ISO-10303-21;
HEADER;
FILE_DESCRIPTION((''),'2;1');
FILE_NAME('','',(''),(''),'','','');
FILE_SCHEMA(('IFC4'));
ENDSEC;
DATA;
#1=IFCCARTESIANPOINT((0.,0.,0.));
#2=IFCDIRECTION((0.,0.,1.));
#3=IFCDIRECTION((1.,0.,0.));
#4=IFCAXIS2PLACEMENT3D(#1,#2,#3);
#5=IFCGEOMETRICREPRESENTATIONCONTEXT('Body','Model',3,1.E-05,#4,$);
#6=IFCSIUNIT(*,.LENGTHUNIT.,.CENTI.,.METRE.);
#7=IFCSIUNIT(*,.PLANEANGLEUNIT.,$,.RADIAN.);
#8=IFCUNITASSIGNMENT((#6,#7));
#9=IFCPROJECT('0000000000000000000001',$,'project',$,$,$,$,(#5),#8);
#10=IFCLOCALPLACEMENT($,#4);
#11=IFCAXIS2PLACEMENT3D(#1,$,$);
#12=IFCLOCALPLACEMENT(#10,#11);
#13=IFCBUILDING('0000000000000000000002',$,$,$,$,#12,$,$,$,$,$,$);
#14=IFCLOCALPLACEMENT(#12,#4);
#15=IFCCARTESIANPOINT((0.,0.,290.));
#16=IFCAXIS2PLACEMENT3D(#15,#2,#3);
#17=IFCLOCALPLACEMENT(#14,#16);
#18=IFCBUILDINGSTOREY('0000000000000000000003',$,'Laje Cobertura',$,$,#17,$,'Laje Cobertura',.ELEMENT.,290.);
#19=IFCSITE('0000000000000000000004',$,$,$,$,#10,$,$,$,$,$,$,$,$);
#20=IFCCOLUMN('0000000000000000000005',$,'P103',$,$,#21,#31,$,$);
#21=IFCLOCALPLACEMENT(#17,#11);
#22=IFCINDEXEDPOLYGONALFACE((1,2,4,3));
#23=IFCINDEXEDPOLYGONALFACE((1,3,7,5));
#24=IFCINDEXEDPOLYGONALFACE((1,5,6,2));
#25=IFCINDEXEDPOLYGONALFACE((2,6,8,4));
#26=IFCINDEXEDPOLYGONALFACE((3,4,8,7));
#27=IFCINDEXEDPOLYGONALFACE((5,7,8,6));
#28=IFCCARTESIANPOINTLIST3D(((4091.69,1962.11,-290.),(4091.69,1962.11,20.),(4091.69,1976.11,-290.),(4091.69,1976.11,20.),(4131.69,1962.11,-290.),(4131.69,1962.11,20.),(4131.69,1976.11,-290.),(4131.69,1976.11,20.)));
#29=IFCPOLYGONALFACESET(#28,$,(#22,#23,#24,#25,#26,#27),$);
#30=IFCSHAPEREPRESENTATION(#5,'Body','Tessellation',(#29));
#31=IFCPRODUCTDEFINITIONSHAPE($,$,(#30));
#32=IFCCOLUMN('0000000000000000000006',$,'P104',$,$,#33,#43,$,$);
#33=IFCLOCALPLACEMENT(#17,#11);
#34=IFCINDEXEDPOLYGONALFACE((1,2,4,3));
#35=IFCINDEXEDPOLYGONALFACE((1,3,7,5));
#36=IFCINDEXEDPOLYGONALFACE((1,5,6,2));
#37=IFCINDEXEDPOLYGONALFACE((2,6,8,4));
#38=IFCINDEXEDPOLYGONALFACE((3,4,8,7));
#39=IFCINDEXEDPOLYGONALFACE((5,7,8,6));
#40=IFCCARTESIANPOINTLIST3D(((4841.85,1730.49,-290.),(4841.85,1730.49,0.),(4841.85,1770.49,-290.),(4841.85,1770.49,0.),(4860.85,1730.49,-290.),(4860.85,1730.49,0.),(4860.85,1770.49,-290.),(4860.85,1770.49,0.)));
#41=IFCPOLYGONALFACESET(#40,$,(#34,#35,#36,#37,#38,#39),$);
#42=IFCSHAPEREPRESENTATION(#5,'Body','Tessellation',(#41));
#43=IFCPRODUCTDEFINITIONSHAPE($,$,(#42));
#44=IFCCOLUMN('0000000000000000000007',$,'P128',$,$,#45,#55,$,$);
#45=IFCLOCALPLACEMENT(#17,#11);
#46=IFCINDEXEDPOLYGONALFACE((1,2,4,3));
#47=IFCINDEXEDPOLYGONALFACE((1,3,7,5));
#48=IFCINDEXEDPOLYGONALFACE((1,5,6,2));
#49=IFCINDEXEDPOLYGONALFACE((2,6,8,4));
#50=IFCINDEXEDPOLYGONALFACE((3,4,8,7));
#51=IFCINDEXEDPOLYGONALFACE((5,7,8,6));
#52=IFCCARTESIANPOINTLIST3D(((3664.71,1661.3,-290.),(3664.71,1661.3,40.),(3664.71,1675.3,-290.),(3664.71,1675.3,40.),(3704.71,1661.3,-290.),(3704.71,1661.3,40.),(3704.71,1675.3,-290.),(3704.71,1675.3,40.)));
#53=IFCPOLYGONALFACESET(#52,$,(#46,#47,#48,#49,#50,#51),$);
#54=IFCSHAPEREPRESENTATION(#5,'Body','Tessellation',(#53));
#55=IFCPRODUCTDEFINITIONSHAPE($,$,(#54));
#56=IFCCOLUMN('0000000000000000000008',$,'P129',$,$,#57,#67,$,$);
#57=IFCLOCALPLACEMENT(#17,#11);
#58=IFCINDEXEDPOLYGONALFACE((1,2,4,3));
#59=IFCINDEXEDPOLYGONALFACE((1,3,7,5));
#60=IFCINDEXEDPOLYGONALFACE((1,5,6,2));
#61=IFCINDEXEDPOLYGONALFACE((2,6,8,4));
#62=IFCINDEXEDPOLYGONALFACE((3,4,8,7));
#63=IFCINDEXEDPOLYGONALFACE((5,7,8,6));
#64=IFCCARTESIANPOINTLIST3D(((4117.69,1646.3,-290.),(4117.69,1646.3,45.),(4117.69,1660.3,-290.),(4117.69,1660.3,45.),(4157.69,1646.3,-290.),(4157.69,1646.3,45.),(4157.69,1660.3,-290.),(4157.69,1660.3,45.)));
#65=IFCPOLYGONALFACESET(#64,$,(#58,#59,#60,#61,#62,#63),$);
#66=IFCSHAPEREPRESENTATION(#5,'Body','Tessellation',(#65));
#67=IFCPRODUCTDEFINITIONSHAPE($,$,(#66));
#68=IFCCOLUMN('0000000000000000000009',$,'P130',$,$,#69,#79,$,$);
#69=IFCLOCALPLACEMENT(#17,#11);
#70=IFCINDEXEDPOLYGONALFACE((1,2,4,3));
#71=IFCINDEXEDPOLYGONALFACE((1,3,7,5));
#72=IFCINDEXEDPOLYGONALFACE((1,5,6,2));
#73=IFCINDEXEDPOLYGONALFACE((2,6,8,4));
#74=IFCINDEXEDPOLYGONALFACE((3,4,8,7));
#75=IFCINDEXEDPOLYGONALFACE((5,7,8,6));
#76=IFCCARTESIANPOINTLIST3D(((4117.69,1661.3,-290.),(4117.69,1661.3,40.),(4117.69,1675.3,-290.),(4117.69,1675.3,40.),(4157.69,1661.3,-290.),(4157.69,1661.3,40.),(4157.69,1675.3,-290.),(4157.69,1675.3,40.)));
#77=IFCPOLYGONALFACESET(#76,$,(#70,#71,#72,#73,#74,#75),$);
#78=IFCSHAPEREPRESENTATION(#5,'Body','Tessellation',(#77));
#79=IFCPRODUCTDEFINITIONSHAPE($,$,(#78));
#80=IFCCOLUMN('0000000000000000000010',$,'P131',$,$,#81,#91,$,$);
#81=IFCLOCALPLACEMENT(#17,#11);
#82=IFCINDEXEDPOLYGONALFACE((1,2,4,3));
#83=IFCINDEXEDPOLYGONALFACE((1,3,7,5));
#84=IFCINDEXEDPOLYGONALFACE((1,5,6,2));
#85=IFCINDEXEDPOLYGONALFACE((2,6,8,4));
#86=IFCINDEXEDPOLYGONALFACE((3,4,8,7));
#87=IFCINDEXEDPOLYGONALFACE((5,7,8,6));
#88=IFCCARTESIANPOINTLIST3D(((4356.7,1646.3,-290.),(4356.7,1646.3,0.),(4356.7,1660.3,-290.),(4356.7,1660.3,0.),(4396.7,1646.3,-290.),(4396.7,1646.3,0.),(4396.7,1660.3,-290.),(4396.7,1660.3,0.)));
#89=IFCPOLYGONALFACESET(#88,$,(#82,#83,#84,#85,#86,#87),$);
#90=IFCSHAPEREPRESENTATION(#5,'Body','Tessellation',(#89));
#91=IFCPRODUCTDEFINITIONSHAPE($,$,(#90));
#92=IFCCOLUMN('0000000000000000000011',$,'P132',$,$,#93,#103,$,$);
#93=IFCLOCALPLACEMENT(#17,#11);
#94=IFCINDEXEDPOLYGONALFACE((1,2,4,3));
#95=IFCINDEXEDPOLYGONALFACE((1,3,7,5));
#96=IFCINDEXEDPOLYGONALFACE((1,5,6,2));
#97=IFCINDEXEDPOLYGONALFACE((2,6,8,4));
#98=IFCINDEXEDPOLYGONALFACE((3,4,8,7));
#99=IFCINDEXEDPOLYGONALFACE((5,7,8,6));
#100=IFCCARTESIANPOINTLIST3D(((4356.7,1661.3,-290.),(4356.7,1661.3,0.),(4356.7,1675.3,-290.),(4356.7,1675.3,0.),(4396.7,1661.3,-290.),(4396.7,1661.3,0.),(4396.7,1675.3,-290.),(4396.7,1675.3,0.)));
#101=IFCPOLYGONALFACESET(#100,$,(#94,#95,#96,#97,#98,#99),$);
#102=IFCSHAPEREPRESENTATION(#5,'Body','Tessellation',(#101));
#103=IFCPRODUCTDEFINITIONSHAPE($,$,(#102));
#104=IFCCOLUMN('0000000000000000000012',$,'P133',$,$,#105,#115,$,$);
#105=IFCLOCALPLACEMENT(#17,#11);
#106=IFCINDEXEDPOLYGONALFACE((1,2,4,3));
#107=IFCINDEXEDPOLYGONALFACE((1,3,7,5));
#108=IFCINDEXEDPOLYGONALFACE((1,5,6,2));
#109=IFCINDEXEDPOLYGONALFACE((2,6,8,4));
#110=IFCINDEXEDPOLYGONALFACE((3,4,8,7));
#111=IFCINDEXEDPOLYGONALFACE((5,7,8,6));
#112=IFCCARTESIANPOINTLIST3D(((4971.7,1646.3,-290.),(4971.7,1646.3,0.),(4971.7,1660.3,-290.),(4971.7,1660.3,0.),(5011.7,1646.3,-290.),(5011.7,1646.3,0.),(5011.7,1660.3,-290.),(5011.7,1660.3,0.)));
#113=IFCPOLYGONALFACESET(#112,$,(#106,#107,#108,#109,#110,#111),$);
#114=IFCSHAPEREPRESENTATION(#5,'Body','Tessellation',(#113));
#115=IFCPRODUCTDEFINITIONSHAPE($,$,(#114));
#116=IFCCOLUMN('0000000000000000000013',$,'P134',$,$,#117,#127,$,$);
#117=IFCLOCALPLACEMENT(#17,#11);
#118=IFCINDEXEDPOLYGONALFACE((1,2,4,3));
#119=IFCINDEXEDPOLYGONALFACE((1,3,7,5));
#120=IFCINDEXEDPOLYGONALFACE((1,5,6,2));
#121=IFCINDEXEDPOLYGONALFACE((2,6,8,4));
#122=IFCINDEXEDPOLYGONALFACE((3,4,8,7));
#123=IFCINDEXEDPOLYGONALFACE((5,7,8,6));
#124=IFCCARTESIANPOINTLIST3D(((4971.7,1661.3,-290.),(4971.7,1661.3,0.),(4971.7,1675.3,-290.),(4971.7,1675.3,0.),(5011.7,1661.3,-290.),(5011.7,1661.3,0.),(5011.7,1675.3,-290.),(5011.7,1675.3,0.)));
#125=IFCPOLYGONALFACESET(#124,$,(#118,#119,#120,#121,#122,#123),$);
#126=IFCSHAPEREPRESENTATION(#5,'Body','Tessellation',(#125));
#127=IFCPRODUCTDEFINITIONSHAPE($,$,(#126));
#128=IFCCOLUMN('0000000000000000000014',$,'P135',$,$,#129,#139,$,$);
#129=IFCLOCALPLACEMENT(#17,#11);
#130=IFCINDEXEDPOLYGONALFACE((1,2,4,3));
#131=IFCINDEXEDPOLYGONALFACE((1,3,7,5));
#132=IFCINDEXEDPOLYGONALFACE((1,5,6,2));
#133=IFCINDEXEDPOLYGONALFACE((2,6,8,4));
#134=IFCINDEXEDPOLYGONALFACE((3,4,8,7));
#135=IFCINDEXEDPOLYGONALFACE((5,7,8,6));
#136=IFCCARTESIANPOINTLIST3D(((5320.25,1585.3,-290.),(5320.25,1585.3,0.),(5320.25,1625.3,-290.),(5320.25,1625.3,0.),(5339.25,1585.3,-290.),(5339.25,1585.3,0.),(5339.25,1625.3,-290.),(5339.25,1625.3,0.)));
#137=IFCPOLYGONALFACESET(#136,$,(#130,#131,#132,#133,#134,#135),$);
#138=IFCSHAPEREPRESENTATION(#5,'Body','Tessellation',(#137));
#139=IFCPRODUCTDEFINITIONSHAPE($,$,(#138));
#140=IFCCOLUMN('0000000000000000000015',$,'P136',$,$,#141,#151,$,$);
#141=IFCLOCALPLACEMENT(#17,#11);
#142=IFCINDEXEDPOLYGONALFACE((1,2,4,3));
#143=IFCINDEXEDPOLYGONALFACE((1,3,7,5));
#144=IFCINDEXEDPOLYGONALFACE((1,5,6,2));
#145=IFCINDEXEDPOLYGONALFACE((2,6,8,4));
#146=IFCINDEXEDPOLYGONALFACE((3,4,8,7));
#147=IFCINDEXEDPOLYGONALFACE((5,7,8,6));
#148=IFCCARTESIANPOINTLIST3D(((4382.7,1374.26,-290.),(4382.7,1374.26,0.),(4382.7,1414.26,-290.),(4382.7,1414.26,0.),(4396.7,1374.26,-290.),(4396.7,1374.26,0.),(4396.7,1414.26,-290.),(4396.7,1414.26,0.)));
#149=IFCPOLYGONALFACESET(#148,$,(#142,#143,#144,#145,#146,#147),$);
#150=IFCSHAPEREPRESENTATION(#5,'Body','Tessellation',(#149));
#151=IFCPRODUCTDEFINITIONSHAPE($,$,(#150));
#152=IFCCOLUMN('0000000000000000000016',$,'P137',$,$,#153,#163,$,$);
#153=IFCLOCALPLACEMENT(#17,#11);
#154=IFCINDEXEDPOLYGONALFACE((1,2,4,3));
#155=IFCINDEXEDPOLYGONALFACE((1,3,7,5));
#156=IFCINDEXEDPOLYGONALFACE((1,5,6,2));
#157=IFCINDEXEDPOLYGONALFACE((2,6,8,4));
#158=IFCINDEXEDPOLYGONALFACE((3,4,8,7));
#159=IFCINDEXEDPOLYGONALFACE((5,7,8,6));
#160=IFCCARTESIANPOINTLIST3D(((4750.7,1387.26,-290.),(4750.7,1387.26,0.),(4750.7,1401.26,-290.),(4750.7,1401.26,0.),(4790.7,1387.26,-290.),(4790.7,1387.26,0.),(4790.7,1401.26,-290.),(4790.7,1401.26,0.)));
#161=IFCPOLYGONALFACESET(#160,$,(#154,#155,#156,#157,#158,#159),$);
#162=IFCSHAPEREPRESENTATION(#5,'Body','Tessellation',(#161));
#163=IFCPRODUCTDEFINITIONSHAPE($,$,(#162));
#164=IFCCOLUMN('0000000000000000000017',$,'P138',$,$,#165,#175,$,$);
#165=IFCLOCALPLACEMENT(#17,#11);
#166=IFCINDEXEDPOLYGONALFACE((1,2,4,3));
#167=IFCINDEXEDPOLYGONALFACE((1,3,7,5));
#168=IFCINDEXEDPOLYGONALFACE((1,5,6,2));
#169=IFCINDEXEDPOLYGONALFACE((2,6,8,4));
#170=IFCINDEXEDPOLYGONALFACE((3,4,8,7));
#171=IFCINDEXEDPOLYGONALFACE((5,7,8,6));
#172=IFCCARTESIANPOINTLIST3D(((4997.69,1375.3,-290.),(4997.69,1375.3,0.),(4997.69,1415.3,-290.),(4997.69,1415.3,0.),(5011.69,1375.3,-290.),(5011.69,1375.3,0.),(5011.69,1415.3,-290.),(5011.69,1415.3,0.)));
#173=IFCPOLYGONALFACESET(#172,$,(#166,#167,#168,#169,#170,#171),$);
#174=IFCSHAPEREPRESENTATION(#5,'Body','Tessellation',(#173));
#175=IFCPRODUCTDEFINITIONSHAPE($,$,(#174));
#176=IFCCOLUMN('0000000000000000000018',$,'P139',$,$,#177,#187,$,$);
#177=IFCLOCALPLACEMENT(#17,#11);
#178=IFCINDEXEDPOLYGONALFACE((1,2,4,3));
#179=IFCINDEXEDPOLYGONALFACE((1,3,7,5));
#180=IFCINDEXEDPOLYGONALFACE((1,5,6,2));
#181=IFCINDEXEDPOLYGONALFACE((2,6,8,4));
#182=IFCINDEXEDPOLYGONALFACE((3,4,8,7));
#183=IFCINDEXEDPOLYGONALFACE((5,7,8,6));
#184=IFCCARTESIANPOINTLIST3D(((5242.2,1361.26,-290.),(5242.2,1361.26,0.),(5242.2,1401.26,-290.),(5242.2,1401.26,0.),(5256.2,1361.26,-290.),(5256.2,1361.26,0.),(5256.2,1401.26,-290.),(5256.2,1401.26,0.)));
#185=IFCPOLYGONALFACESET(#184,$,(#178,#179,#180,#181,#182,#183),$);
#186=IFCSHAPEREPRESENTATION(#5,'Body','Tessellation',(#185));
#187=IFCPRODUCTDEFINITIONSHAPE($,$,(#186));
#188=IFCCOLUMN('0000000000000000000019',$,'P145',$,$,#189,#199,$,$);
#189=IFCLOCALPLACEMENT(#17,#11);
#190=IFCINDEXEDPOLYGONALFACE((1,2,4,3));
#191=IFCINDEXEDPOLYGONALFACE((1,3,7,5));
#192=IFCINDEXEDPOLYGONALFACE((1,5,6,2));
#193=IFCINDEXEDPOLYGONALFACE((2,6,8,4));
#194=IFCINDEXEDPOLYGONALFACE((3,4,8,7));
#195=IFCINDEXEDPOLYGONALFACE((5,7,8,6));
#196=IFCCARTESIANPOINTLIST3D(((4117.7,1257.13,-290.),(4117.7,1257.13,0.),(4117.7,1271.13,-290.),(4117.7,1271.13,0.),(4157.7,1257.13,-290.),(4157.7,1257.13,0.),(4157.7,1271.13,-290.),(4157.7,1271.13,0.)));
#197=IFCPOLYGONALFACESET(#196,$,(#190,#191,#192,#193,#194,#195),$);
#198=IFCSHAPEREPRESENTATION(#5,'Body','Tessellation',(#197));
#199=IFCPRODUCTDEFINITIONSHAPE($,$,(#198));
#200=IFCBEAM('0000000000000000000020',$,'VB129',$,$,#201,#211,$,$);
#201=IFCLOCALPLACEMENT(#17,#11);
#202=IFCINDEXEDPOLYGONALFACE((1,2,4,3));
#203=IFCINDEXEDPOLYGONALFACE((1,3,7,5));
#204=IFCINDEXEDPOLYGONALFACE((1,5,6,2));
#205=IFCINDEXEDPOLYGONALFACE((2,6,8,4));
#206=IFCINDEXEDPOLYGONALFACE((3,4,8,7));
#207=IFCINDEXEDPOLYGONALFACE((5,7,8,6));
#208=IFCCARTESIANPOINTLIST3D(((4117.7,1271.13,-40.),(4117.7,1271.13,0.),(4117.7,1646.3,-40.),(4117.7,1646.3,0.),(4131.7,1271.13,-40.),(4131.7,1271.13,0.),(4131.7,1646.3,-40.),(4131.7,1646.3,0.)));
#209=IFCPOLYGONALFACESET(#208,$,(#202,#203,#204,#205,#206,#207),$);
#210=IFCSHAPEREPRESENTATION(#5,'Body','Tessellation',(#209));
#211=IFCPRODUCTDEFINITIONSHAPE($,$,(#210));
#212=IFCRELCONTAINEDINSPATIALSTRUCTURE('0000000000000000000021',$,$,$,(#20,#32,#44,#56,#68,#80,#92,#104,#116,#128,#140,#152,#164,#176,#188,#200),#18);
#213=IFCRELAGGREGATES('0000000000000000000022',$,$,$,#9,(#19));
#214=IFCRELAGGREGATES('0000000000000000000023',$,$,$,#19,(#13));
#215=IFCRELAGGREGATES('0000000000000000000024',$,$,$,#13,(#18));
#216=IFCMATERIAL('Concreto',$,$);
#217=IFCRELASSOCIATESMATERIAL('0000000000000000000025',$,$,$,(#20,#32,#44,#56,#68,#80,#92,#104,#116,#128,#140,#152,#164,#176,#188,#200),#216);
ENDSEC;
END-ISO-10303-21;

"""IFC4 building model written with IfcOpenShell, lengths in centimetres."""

from ifc_helpers import new_model, si_unit, frame, origin, origin_with_axes, origin_2d_with_axis, place, context, project, spatial, rectangle, extrude, material, element, save


model = new_model("IFC4")

# Units and contexts
model_context = context("Model", 3, precision=1e-05, world=origin_with_axes(), identifier="Body")
ifc_project = project(units=[si_unit("LENGTHUNIT", "METRE", prefix="CENTI"), si_unit("PLANEANGLEUNIT", "RADIAN")], contexts=[model_context])

# Site, building, storey
site_placement = place(None, origin_with_axes())
site = spatial("IfcSite", under=ifc_project, at=site_placement)
building_placement = place(site_placement, origin())
building = spatial("IfcBuilding", under=site, at=building_placement)
placement = place(building_placement, origin_with_axes())
storey_placement = place(placement, frame((0.0, 0.0, 290.0), z_axis=(0.0, 0.0, 1.0), x_axis=(1.0, 0.0, 0.0)))
storey = spatial("IfcBuildingStorey", under=building, at=storey_placement, Name="Laje Cobertura", LongName="Laje Cobertura", CompositionType="ELEMENT", Elevation=290.0)

# Columns
ifc_material = material(Name="Concreto")
column_1_placement = place(storey_placement, frame((4111.69, 1969.11, 20.0), z_axis=(0.0, 0.0, 1.0), x_axis=(1.0, 0.0, 0.0)))
element("IfcColumn", 1, at=column_1_placement, inside=storey, material=ifc_material, Name="P103", context=model_context, shape_type="SolidModel", body=[
    extrude(rectangle(XDim=14.0, YDim=40.0, at=origin_2d_with_axis()), frame((0.0, 0.0, 0.0), z_axis=(0.0, 0.0, 1.0), x_axis=(0.0, -1.0, 0.0)), (0.0, 0.0, -1.0), 310.0),
])
column_2_placement = place(storey_placement, frame((4851.35, 1750.49, 0.0), z_axis=(0.0, 0.0, 1.0), x_axis=(1.0, 0.0, 0.0)))
element("IfcColumn", 2, at=column_2_placement, inside=storey, material=ifc_material, Name="P104", context=model_context, shape_type="SolidModel", body=[
    extrude(rectangle(XDim=19.0, YDim=40.0, at=origin_2d_with_axis()), origin_with_axes(), (0.0, 0.0, -1.0), 290.0),
])
column_3_placement = place(storey_placement, frame((3684.71, 1668.3, 40.0), z_axis=(0.0, 0.0, 1.0), x_axis=(1.0, 0.0, 0.0)))
element("IfcColumn", 3, at=column_3_placement, inside=storey, material=ifc_material, Name="P128", context=model_context, shape_type="SolidModel", body=[
    extrude(rectangle(XDim=14.0, YDim=40.0, at=origin_2d_with_axis()), frame((0.0, 0.0, 0.0), z_axis=(0.0, 0.0, 1.0), x_axis=(0.0, -1.0, 0.0)), (0.0, 0.0, -1.0), 330.0),
])
column_4_placement = place(storey_placement, frame((4137.69, 1653.3, 45.0), z_axis=(0.0, 0.0, 1.0), x_axis=(1.0, 0.0, 0.0)))
element("IfcColumn", 4, at=column_4_placement, inside=storey, material=ifc_material, Name="P129", context=model_context, shape_type="SolidModel", body=[
    extrude(rectangle(XDim=14.0, YDim=40.0, at=origin_2d_with_axis()), frame((0.0, 0.0, 0.0), z_axis=(0.0, 0.0, 1.0), x_axis=(0.0, -1.0, 0.0)), (0.0, 0.0, -1.0), 335.0),
])
column_5_placement = place(storey_placement, frame((4137.69, 1668.3, 40.0), z_axis=(0.0, 0.0, 1.0), x_axis=(1.0, 0.0, 0.0)))
element("IfcColumn", 5, at=column_5_placement, inside=storey, material=ifc_material, Name="P130", context=model_context, shape_type="SolidModel", body=[
    extrude(rectangle(XDim=14.0, YDim=40.0, at=origin_2d_with_axis()), frame((0.0, 0.0, 0.0), z_axis=(0.0, 0.0, 1.0), x_axis=(0.0, -1.0, 0.0)), (0.0, 0.0, -1.0), 330.0),
])
for number, where, z_axis, x_axis, name in (
    (6, (4376.7, 1653.3, 0.0), (0.0, 0.0, 1.0), (1.0, 0.0, 0.0), "P131"),
    (7, (4376.7, 1668.3, 0.0), (0.0, 0.0, 1.0), (1.0, 0.0, 0.0), "P132"),
    (8, (4991.7, 1653.3, 0.0), (0.0, 0.0, 1.0), (1.0, 0.0, 0.0), "P133"),
    (9, (4991.7, 1668.3, 0.0), (0.0, 0.0, 1.0), (1.0, 0.0, 0.0), "P134"),
):
    element("IfcColumn", number, at=place(storey_placement, frame(where, z_axis=z_axis, x_axis=x_axis)), inside=storey, material=ifc_material, Name=name, context=model_context, shape_type="SolidModel", body=[
        extrude(rectangle(XDim=14.0, YDim=40.0, at=origin_2d_with_axis()), frame((0.0, 0.0, 0.0), z_axis=(0.0, 0.0, 1.0), x_axis=(0.0, -1.0, 0.0)), (0.0, 0.0, -1.0), 290.0),
    ])
column_6_placement = place(storey_placement, frame((5329.75, 1605.3, 0.0), z_axis=(0.0, 0.0, 1.0), x_axis=(1.0, 0.0, 0.0)))
element("IfcColumn", 10, at=column_6_placement, inside=storey, material=ifc_material, Name="P135", context=model_context, shape_type="SolidModel", body=[
    extrude(rectangle(XDim=19.0, YDim=40.0, at=origin_2d_with_axis()), origin_with_axes(), (0.0, 0.0, -1.0), 290.0),
])
column_7_placement = place(storey_placement, frame((4389.7, 1394.26, 0.0), z_axis=(0.0, 0.0, 1.0), x_axis=(1.0, 0.0, 0.0)))
element("IfcColumn", 11, at=column_7_placement, inside=storey, material=ifc_material, Name="P136", context=model_context, shape_type="SolidModel", body=[
    extrude(rectangle(XDim=14.0, YDim=40.0, at=origin_2d_with_axis()), frame((0.0, 0.0, 0.0), z_axis=(0.0, 0.0, 1.0), x_axis=(-1.0, 0.0, 0.0)), (0.0, 0.0, -1.0), 290.0),
])
column_8_placement = place(storey_placement, frame((4770.7, 1394.26, 0.0), z_axis=(0.0, 0.0, 1.0), x_axis=(1.0, 0.0, 0.0)))
element("IfcColumn", 12, at=column_8_placement, inside=storey, material=ifc_material, Name="P137", context=model_context, shape_type="SolidModel", body=[
    extrude(rectangle(XDim=14.0, YDim=40.0, at=origin_2d_with_axis()), frame((0.0, 0.0, 0.0), z_axis=(0.0, 0.0, 1.0), x_axis=(0.0, -1.0, 0.0)), (0.0, 0.0, -1.0), 290.0),
])
column_9_placement = place(storey_placement, frame((5004.69, 1395.3, 0.0), z_axis=(0.0, 0.0, 1.0), x_axis=(1.0, 0.0, 0.0)))
element("IfcColumn", 13, at=column_9_placement, inside=storey, material=ifc_material, Name="P138", context=model_context, shape_type="SolidModel", body=[
    extrude(rectangle(XDim=14.0, YDim=40.0, at=origin_2d_with_axis()), origin_with_axes(), (0.0, 0.0, -1.0), 290.0),
])
column_10_placement = place(storey_placement, frame((5249.2, 1381.26, 0.0), z_axis=(0.0, 0.0, 1.0), x_axis=(1.0, 0.0, 0.0)))
element("IfcColumn", 14, at=column_10_placement, inside=storey, material=ifc_material, Name="P139", context=model_context, shape_type="SolidModel", body=[
    extrude(rectangle(XDim=14.0, YDim=40.0, at=origin_2d_with_axis()), frame((0.0, 0.0, 0.0), z_axis=(0.0, 0.0, 1.0), x_axis=(-1.0, 0.0, 0.0)), (0.0, 0.0, -1.0), 290.0),
])
column_11_placement = place(storey_placement, frame((4137.7, 1264.13, 0.0), z_axis=(0.0, 0.0, 1.0), x_axis=(1.0, 0.0, 0.0)))
element("IfcColumn", 15, at=column_11_placement, inside=storey, material=ifc_material, Name="P145", context=model_context, shape_type="SolidModel", body=[
    extrude(rectangle(XDim=14.0, YDim=40.0, at=origin_2d_with_axis()), frame((0.0, 0.0, 0.0), z_axis=(0.0, 0.0, 1.0), x_axis=(0.0, -1.0, 0.0)), (0.0, 0.0, -1.0), 290.0),
])

# Beam
beam_1_placement = place(storey_placement, frame((4124.7, 1458.71, 0.0), z_axis=(0.0, 0.0, 1.0), x_axis=(1.0, 0.0, 0.0)))
element("IfcBeam", 16, at=beam_1_placement, inside=storey, material=ifc_material, Name="VB129", context=model_context, shape_type="SolidModel", body=[
    extrude(rectangle(XDim=14.0, YDim=40.0, at=origin_2d_with_axis()), frame((0.0, -187.59, -20.0), z_axis=(0.0, 1.0, 0.0), x_axis=(1.0, 0.0, 0.0)), (0.0, 0.0, 1.0), 375.17),
])

save(model, "model.ifc")
